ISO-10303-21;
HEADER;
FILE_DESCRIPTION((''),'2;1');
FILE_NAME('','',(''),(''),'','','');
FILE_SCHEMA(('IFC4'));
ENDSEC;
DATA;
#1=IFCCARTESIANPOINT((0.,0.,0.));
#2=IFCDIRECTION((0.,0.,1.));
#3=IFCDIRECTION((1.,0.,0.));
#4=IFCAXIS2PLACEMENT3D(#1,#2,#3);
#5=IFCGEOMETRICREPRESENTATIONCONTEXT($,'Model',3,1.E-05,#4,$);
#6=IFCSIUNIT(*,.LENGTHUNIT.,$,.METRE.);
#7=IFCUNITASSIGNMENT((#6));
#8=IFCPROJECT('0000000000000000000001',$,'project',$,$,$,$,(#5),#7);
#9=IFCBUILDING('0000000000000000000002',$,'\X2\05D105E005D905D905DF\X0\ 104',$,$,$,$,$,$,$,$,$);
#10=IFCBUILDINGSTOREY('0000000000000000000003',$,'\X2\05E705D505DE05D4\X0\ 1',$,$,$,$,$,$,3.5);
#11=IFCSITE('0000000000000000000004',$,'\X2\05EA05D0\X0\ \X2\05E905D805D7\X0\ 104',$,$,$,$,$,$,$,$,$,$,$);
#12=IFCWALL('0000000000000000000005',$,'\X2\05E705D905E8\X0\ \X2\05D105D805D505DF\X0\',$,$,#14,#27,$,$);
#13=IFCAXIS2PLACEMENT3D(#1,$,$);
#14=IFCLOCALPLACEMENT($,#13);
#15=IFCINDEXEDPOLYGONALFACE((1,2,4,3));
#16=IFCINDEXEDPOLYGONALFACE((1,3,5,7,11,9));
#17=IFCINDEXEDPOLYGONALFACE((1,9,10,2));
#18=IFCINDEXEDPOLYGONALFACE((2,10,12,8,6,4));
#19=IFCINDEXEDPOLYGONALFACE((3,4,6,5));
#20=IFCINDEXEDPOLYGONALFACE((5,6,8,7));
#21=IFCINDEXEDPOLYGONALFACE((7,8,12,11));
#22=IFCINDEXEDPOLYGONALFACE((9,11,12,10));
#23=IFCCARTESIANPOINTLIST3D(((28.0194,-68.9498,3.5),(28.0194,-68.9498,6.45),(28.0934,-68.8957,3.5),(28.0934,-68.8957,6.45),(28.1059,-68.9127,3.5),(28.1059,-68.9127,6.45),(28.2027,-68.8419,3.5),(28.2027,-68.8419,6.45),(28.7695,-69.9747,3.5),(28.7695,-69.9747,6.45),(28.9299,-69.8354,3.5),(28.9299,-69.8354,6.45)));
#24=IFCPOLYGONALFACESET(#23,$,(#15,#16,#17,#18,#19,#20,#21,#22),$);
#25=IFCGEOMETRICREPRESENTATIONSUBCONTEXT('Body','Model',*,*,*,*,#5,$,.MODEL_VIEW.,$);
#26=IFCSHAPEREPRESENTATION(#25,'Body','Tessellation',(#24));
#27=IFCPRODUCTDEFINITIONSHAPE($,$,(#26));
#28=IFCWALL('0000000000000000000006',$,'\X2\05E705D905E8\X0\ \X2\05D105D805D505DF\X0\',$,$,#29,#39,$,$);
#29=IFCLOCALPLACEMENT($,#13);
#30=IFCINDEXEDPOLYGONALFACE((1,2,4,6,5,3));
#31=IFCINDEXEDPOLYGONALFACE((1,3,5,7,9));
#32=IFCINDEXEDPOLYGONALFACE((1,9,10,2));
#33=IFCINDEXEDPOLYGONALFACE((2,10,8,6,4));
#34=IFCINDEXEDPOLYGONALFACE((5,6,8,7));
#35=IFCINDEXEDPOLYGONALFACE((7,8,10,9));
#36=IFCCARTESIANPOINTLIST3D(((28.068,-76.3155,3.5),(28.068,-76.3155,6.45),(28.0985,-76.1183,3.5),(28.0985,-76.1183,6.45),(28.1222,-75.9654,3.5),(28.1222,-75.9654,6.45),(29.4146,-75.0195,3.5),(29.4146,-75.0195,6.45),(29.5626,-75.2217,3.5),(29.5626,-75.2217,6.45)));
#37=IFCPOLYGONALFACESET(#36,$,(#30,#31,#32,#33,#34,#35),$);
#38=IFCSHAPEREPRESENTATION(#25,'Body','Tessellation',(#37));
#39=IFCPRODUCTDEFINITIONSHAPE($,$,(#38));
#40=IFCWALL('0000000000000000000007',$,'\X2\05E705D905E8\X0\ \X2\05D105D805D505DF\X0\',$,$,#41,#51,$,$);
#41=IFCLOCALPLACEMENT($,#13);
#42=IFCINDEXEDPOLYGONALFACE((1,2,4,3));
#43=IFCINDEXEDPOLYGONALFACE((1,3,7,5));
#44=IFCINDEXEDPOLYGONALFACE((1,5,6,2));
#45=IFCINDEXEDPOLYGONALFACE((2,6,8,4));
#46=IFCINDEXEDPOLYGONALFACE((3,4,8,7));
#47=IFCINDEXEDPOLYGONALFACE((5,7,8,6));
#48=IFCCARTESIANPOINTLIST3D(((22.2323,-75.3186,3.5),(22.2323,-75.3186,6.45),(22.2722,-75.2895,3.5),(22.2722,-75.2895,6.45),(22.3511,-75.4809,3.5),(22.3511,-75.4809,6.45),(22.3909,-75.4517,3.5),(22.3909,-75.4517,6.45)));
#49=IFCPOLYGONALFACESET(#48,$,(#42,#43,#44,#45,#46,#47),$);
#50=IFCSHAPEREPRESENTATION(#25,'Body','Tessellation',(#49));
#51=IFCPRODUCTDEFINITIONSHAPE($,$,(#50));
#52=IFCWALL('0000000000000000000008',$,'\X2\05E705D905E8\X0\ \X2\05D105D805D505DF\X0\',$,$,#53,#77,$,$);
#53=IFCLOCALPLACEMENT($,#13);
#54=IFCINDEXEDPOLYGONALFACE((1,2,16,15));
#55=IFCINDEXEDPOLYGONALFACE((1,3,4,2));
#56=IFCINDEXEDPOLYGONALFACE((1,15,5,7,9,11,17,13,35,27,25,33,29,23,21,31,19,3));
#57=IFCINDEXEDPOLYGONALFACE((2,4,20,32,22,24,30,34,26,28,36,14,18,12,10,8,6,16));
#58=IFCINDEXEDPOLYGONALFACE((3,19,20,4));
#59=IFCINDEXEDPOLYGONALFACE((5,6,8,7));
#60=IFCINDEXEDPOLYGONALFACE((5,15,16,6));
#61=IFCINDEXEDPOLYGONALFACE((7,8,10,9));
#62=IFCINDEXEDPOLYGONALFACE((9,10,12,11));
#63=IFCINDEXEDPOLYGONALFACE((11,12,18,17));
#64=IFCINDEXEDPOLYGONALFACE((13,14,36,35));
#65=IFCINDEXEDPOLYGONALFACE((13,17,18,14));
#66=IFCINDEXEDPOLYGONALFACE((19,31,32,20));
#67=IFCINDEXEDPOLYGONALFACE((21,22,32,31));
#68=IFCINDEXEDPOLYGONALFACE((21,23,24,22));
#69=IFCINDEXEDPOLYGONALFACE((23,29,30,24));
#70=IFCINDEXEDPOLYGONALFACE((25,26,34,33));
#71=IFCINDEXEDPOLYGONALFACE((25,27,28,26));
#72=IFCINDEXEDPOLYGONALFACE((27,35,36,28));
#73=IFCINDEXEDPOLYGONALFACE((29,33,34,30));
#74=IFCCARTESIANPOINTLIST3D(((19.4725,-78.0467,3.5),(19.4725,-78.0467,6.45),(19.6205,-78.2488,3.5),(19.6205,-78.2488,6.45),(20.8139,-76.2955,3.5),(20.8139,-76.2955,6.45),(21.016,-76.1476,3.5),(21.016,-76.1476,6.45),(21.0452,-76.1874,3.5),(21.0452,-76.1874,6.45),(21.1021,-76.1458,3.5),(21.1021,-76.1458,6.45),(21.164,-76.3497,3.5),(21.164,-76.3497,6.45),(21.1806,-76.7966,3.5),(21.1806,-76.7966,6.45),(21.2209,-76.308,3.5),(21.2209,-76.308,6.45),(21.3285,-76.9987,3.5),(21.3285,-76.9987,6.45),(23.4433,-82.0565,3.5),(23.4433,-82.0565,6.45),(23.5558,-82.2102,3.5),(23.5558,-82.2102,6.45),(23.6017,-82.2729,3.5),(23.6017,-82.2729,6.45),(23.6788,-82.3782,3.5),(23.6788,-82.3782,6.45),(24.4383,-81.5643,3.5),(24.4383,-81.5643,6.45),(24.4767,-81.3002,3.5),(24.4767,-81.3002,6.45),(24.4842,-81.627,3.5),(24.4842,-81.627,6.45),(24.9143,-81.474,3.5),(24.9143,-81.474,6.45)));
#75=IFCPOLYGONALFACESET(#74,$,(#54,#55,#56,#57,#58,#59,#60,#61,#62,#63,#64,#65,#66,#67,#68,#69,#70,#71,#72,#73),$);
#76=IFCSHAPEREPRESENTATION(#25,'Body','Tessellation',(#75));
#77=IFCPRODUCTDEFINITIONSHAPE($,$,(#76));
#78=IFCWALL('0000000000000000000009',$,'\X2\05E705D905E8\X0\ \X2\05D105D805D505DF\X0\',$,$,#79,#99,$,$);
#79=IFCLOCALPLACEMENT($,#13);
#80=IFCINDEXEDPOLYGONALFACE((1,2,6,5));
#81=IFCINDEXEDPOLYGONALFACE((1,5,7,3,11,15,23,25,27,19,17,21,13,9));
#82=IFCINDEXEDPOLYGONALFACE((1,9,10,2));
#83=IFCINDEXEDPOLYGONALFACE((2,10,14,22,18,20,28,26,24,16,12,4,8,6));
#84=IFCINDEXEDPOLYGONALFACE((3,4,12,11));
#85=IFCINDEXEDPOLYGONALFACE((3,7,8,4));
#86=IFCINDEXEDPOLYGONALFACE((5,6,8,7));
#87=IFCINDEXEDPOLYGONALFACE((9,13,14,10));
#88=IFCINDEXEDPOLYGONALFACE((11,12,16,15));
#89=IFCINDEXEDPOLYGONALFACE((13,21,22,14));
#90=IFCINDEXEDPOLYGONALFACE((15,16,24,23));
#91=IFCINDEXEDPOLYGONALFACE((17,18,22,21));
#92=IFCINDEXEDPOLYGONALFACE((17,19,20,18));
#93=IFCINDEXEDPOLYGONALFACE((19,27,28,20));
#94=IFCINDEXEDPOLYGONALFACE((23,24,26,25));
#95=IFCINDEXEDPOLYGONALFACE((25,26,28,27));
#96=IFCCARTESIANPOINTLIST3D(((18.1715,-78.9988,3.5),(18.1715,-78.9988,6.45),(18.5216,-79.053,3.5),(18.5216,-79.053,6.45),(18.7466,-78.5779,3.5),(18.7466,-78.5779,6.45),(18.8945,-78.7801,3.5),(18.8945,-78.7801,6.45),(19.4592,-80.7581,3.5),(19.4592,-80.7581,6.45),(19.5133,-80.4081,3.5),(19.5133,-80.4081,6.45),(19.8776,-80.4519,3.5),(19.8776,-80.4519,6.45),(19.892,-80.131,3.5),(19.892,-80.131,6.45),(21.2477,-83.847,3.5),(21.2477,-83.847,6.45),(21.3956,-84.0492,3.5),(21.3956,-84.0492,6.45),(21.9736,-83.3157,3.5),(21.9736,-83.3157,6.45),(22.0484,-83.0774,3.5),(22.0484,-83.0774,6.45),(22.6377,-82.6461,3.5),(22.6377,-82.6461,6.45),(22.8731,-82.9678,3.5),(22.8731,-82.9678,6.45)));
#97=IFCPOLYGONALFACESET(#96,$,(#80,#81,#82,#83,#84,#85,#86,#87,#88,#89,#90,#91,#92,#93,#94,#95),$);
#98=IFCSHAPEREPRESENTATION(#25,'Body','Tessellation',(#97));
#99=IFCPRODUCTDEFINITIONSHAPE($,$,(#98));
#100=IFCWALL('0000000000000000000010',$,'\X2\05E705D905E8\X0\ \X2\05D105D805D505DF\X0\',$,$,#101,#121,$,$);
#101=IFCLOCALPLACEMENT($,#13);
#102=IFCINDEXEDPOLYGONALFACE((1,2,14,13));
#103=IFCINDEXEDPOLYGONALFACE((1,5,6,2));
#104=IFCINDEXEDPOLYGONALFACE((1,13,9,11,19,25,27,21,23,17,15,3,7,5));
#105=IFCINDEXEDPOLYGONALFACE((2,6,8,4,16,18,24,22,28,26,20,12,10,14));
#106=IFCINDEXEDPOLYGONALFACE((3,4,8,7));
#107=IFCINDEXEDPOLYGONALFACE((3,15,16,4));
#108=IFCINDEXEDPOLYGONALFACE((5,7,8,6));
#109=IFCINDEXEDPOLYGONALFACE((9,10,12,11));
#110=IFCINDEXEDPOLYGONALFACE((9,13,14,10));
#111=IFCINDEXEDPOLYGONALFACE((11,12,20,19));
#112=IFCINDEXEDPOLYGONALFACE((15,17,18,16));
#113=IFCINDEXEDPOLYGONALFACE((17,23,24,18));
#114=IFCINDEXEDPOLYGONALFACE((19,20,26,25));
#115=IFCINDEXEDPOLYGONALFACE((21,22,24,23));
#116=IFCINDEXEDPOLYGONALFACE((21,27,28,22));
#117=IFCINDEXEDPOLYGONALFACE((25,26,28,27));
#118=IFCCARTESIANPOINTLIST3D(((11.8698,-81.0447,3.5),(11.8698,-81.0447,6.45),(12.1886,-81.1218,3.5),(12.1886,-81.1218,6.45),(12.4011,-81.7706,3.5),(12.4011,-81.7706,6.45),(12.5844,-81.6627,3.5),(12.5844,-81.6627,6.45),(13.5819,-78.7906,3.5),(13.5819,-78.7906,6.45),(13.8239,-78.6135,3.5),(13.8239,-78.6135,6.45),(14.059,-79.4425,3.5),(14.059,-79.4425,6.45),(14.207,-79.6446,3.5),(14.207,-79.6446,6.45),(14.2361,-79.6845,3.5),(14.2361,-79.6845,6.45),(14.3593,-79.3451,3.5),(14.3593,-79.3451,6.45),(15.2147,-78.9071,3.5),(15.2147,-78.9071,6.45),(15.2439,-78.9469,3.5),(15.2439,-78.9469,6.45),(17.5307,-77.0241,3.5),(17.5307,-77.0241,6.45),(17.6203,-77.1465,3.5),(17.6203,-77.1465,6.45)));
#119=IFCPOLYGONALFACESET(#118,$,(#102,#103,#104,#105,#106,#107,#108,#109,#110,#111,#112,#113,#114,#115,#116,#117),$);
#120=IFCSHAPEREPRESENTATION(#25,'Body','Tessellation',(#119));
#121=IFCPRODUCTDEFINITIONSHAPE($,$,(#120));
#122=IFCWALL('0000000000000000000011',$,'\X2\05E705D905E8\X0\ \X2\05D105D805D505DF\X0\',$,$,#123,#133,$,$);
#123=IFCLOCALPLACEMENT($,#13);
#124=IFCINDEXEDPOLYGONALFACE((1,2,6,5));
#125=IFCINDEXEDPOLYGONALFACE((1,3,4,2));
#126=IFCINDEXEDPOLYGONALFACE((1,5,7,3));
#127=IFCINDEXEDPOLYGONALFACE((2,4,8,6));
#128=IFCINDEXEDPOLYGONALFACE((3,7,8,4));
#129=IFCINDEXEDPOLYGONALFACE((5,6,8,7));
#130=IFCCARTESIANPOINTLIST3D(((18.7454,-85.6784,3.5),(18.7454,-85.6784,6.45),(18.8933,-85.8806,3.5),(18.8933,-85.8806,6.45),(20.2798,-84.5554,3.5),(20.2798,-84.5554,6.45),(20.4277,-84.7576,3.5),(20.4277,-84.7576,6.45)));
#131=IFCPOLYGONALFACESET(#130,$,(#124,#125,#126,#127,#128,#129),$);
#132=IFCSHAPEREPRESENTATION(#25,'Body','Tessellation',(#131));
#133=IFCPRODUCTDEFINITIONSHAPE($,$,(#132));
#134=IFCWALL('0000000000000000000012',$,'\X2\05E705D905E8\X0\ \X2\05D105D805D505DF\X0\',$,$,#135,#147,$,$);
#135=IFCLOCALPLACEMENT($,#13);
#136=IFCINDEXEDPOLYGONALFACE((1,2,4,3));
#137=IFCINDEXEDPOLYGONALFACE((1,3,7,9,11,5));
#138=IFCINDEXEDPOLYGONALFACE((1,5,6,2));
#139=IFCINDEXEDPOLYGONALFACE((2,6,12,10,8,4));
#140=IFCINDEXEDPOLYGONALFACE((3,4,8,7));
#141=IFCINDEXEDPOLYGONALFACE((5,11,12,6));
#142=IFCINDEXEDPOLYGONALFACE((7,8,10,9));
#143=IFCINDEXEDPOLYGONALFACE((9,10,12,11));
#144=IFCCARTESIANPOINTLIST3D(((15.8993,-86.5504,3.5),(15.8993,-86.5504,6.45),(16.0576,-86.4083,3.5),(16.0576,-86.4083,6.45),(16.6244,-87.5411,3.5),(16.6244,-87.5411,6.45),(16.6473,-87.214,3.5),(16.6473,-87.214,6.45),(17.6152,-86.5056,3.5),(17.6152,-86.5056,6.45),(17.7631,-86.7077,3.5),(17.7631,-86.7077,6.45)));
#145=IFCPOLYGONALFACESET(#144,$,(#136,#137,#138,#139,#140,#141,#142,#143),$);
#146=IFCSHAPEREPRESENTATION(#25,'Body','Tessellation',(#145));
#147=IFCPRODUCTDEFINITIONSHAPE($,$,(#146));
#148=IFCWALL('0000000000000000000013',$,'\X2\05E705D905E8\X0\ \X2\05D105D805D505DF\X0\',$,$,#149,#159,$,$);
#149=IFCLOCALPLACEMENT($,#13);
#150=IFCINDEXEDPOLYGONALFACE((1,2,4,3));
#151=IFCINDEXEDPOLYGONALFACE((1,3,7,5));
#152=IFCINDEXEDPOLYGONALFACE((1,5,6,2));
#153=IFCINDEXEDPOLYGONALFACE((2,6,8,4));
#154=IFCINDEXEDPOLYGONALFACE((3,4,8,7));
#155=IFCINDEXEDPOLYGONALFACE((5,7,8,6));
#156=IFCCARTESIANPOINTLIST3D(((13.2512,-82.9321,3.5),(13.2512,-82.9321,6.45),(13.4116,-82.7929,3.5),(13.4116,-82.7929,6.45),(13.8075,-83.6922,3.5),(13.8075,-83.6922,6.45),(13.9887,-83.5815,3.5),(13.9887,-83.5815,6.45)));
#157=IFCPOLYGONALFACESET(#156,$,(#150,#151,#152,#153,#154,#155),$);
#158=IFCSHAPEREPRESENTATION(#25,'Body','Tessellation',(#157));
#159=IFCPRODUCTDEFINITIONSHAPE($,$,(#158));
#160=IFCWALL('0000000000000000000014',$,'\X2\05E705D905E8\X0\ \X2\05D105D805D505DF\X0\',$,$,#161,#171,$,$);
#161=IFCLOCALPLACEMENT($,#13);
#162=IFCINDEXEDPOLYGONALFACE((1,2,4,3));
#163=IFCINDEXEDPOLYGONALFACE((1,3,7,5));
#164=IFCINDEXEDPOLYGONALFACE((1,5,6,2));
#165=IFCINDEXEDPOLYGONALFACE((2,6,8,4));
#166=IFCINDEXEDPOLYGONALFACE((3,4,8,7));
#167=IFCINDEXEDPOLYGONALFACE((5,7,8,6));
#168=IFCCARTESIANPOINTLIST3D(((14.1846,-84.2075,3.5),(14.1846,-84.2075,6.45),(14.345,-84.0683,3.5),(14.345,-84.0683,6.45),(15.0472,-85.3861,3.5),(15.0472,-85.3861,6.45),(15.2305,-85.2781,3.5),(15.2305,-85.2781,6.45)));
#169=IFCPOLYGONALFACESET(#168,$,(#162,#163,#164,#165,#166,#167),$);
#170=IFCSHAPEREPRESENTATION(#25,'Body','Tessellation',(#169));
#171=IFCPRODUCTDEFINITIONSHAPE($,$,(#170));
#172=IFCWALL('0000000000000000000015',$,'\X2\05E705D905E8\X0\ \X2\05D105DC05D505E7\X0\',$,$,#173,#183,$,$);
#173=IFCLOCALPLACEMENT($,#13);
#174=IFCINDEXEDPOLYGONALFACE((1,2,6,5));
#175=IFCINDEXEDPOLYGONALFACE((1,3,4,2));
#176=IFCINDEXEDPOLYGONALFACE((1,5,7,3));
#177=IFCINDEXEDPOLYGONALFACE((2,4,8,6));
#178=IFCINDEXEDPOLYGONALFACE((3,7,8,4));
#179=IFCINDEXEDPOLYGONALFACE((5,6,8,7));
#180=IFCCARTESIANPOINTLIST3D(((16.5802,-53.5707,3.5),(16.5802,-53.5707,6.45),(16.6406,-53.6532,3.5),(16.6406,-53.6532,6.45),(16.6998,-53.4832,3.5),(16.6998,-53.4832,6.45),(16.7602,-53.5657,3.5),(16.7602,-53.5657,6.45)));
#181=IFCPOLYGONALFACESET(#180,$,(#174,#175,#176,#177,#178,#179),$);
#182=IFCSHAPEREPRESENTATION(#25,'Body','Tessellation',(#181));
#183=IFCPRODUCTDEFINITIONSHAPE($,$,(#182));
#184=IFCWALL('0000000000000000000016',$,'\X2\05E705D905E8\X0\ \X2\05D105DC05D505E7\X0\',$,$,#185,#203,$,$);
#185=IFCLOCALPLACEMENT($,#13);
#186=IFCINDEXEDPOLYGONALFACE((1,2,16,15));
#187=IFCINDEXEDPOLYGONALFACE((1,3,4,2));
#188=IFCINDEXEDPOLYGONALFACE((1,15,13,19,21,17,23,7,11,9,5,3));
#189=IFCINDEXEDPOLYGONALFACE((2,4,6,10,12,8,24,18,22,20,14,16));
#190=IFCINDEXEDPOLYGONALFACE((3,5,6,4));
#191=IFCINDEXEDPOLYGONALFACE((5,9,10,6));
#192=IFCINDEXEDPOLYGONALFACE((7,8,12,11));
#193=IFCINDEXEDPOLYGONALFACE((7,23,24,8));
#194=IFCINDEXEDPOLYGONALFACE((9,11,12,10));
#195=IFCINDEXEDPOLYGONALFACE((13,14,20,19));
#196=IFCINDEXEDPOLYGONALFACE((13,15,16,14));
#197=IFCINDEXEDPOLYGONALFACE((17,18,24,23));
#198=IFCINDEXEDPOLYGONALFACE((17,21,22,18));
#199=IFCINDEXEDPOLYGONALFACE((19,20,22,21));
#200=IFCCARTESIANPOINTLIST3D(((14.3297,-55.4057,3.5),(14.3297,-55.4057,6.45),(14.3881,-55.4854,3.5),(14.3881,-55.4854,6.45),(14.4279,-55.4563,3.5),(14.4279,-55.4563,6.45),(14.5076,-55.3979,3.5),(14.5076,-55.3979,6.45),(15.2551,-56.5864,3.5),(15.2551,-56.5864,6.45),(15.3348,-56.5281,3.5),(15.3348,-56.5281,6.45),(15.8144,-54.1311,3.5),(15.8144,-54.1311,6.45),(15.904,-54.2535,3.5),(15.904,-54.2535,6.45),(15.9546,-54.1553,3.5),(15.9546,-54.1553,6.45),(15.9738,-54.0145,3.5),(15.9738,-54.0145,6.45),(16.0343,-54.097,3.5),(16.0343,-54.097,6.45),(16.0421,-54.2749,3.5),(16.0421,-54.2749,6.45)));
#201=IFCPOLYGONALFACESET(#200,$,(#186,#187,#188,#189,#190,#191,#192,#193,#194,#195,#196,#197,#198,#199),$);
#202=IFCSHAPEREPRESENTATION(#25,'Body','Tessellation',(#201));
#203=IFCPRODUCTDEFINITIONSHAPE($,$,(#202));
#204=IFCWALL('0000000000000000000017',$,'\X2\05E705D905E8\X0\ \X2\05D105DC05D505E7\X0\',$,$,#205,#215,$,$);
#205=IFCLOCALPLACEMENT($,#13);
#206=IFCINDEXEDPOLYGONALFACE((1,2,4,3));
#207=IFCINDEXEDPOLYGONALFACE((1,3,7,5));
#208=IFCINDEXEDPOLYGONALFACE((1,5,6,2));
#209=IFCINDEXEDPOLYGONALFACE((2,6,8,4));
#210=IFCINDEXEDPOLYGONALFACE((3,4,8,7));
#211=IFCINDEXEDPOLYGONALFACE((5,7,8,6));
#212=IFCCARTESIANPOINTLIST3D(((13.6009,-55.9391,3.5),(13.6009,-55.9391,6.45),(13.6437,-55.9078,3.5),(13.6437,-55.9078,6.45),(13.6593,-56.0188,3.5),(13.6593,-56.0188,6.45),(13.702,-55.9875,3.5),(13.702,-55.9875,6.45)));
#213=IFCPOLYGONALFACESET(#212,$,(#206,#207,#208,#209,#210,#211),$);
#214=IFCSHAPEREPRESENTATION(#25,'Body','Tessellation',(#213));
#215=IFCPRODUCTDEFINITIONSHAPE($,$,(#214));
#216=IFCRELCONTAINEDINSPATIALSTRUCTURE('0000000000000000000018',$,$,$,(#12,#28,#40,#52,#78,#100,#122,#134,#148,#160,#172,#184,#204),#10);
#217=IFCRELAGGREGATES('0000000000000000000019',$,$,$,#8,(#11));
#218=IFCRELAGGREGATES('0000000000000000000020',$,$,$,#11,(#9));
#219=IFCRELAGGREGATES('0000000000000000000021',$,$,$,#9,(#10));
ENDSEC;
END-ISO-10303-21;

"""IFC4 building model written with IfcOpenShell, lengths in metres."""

from ifc_helpers import new_model, si_unit, frame, origin_with_axes, context, subcontext, project, spatial, polyline, outline, extrude, element, save


model = new_model("IFC4")

# Units and contexts
model_context = context("Model", 3, precision=1e-05, world=origin_with_axes())
body_context = subcontext(model_context, "Body", "Model", "MODEL_VIEW")
ifc_project = project(units=[si_unit("LENGTHUNIT", "METRE")], contexts=[model_context])

# Site, building, storey
site = spatial("IfcSite", under=ifc_project, Name="תא שטח 104")
building = spatial("IfcBuilding", under=site, Name="בניין 104")
storey = spatial("IfcBuildingStorey", under=building, Name="קומה 1", Elevation=3.5)

# Walls
element("IfcWall", 1, inside=storey, Name="קיר בטון", context=body_context, shape_type="SweptSolid", body=[
    extrude(outline(polyline([(28.0934, -68.8957), (28.0194, -68.9498), (28.7695, -69.9747), (28.9299, -69.8354), (28.2027, -68.8419), (28.1059, -68.9127), (28.0934, -68.8957)])), frame((0.0, 0.0, 3.5)), (0.0, 0.0, 1.0), 2.95),
])
element("IfcWall", 2, inside=storey, Name="קיר בטון", context=body_context, shape_type="SweptSolid", body=[
    extrude(outline(polyline([(29.4146, -75.0195), (28.1222, -75.9654), (28.0985, -76.1183), (28.068, -76.3155), (29.5626, -75.2217), (29.4146, -75.0195)])), frame((0.0, 0.0, 3.5)), (0.0, 0.0, 1.0), 2.95),
])
element("IfcWall", 3, inside=storey, Name="קיר בטון", context=body_context, shape_type="SweptSolid", body=[
    extrude(outline(polyline([(22.3909, -75.4517), (22.2722, -75.2895), (22.2323, -75.3186), (22.3511, -75.4809), (22.3909, -75.4517)])), frame((0.0, 0.0, 3.5)), (0.0, 0.0, 1.0), 2.95),
])
element("IfcWall", 4, inside=storey, Name="קיר בטון", context=body_context, shape_type="SweptSolid", body=[
    extrude(outline(polyline([(20.8139, -76.2955), (21.1806, -76.7966), (19.4725, -78.0467), (19.6205, -78.2488), (21.3285, -76.9987), (24.4767, -81.3002), (23.4433, -82.0565), (23.5558, -82.2102), (24.4383, -81.5643), (24.4842, -81.627), (23.6017, -82.2729), (23.6788, -82.3782), (24.9143, -81.474), (21.164, -76.3497), (21.2209, -76.308), (21.1021, -76.1458), (21.0452, -76.1874), (21.016, -76.1476), (20.8139, -76.2955)])), frame((0.0, 0.0, 3.5)), (0.0, 0.0, 1.0), 2.95),
])
element("IfcWall", 5, inside=storey, Name="קיר בטון", context=body_context, shape_type="SweptSolid", body=[
    extrude(outline(polyline([(19.5133, -80.4081), (18.5216, -79.053), (18.8945, -78.7801), (18.7466, -78.5779), (18.1715, -78.9988), (19.4592, -80.7581), (19.8776, -80.4519), (21.9736, -83.3157), (21.2477, -83.847), (21.3956, -84.0492), (22.8731, -82.9678), (22.6377, -82.6461), (22.0484, -83.0774), (19.892, -80.131), (19.5133, -80.4081)])), frame((0.0, 0.0, 3.5)), (0.0, 0.0, 1.0), 2.95),
])
element("IfcWall", 6, inside=storey, Name="קיר בטון", context=body_context, shape_type="SweptSolid", body=[
    extrude(outline(polyline([(13.5819, -78.7906), (14.059, -79.4425), (11.8698, -81.0447), (12.4011, -81.7706), (12.5844, -81.6627), (12.1886, -81.1218), (14.207, -79.6446), (14.2361, -79.6845), (15.2439, -78.9469), (15.2147, -78.9071), (17.6203, -77.1465), (17.5307, -77.0241), (14.3593, -79.3451), (13.8239, -78.6135), (13.5819, -78.7906)])), frame((0.0, 0.0, 3.5)), (0.0, 0.0, 1.0), 2.95),
])
element("IfcWall", 7, inside=storey, Name="קיר בטון", context=body_context, shape_type="SweptSolid", body=[
    extrude(outline(polyline([(18.8933, -85.8806), (20.4277, -84.7576), (20.2798, -84.5554), (18.7454, -85.6784), (18.8933, -85.8806)])), frame((0.0, 0.0, 3.5)), (0.0, 0.0, 1.0), 2.95),
])
element("IfcWall", 8, inside=storey, Name="קיר בטון", context=body_context, shape_type="SweptSolid", body=[
    extrude(outline(polyline([(15.8993, -86.5504), (16.6244, -87.5411), (17.7631, -86.7077), (17.6152, -86.5056), (16.6473, -87.214), (16.0576, -86.4083), (15.8993, -86.5504)])), frame((0.0, 0.0, 3.5)), (0.0, 0.0, 1.0), 2.95),
])
element("IfcWall", 9, inside=storey, Name="קיר בטון", context=body_context, shape_type="SweptSolid", body=[
    extrude(outline(polyline([(13.2512, -82.9321), (13.8075, -83.6922), (13.9887, -83.5815), (13.4116, -82.7929), (13.2512, -82.9321)])), frame((0.0, 0.0, 3.5)), (0.0, 0.0, 1.0), 2.95),
])
element("IfcWall", 10, inside=storey, Name="קיר בטון", context=body_context, shape_type="SweptSolid", body=[
    extrude(outline(polyline([(14.1846, -84.2075), (15.0472, -85.3861), (15.2305, -85.2781), (14.345, -84.0683), (14.1846, -84.2075)])), frame((0.0, 0.0, 3.5)), (0.0, 0.0, 1.0), 2.95),
])
element("IfcWall", 11, inside=storey, Name="קיר בלוק", context=body_context, shape_type="SweptSolid", body=[
    extrude(outline(polyline([(16.7602, -53.5657), (16.6998, -53.4832), (16.5802, -53.5707), (16.6406, -53.6532), (16.7602, -53.5657)])), frame((0.0, 0.0, 3.5)), (0.0, 0.0, 1.0), 2.95),
])
element("IfcWall", 12, inside=storey, Name="קיר בלוק", context=body_context, shape_type="SweptSolid", body=[
    extrude(outline(polyline([(15.8144, -54.1311), (15.904, -54.2535), (14.3297, -55.4057), (14.3881, -55.4854), (14.4279, -55.4563), (15.2551, -56.5864), (15.3348, -56.5281), (14.5076, -55.3979), (16.0421, -54.2749), (15.9546, -54.1553), (16.0343, -54.097), (15.9738, -54.0145), (15.8144, -54.1311)])), frame((0.0, 0.0, 3.5)), (0.0, 0.0, 1.0), 2.95),
])
element("IfcWall", 13, inside=storey, Name="קיר בלוק", context=body_context, shape_type="SweptSolid", body=[
    extrude(outline(polyline([(13.6437, -55.9078), (13.6009, -55.9391), (13.6593, -56.0188), (13.702, -55.9875), (13.6437, -55.9078)])), frame((0.0, 0.0, 3.5)), (0.0, 0.0, 1.0), 2.95),
])

save(model, "model.ifc")
